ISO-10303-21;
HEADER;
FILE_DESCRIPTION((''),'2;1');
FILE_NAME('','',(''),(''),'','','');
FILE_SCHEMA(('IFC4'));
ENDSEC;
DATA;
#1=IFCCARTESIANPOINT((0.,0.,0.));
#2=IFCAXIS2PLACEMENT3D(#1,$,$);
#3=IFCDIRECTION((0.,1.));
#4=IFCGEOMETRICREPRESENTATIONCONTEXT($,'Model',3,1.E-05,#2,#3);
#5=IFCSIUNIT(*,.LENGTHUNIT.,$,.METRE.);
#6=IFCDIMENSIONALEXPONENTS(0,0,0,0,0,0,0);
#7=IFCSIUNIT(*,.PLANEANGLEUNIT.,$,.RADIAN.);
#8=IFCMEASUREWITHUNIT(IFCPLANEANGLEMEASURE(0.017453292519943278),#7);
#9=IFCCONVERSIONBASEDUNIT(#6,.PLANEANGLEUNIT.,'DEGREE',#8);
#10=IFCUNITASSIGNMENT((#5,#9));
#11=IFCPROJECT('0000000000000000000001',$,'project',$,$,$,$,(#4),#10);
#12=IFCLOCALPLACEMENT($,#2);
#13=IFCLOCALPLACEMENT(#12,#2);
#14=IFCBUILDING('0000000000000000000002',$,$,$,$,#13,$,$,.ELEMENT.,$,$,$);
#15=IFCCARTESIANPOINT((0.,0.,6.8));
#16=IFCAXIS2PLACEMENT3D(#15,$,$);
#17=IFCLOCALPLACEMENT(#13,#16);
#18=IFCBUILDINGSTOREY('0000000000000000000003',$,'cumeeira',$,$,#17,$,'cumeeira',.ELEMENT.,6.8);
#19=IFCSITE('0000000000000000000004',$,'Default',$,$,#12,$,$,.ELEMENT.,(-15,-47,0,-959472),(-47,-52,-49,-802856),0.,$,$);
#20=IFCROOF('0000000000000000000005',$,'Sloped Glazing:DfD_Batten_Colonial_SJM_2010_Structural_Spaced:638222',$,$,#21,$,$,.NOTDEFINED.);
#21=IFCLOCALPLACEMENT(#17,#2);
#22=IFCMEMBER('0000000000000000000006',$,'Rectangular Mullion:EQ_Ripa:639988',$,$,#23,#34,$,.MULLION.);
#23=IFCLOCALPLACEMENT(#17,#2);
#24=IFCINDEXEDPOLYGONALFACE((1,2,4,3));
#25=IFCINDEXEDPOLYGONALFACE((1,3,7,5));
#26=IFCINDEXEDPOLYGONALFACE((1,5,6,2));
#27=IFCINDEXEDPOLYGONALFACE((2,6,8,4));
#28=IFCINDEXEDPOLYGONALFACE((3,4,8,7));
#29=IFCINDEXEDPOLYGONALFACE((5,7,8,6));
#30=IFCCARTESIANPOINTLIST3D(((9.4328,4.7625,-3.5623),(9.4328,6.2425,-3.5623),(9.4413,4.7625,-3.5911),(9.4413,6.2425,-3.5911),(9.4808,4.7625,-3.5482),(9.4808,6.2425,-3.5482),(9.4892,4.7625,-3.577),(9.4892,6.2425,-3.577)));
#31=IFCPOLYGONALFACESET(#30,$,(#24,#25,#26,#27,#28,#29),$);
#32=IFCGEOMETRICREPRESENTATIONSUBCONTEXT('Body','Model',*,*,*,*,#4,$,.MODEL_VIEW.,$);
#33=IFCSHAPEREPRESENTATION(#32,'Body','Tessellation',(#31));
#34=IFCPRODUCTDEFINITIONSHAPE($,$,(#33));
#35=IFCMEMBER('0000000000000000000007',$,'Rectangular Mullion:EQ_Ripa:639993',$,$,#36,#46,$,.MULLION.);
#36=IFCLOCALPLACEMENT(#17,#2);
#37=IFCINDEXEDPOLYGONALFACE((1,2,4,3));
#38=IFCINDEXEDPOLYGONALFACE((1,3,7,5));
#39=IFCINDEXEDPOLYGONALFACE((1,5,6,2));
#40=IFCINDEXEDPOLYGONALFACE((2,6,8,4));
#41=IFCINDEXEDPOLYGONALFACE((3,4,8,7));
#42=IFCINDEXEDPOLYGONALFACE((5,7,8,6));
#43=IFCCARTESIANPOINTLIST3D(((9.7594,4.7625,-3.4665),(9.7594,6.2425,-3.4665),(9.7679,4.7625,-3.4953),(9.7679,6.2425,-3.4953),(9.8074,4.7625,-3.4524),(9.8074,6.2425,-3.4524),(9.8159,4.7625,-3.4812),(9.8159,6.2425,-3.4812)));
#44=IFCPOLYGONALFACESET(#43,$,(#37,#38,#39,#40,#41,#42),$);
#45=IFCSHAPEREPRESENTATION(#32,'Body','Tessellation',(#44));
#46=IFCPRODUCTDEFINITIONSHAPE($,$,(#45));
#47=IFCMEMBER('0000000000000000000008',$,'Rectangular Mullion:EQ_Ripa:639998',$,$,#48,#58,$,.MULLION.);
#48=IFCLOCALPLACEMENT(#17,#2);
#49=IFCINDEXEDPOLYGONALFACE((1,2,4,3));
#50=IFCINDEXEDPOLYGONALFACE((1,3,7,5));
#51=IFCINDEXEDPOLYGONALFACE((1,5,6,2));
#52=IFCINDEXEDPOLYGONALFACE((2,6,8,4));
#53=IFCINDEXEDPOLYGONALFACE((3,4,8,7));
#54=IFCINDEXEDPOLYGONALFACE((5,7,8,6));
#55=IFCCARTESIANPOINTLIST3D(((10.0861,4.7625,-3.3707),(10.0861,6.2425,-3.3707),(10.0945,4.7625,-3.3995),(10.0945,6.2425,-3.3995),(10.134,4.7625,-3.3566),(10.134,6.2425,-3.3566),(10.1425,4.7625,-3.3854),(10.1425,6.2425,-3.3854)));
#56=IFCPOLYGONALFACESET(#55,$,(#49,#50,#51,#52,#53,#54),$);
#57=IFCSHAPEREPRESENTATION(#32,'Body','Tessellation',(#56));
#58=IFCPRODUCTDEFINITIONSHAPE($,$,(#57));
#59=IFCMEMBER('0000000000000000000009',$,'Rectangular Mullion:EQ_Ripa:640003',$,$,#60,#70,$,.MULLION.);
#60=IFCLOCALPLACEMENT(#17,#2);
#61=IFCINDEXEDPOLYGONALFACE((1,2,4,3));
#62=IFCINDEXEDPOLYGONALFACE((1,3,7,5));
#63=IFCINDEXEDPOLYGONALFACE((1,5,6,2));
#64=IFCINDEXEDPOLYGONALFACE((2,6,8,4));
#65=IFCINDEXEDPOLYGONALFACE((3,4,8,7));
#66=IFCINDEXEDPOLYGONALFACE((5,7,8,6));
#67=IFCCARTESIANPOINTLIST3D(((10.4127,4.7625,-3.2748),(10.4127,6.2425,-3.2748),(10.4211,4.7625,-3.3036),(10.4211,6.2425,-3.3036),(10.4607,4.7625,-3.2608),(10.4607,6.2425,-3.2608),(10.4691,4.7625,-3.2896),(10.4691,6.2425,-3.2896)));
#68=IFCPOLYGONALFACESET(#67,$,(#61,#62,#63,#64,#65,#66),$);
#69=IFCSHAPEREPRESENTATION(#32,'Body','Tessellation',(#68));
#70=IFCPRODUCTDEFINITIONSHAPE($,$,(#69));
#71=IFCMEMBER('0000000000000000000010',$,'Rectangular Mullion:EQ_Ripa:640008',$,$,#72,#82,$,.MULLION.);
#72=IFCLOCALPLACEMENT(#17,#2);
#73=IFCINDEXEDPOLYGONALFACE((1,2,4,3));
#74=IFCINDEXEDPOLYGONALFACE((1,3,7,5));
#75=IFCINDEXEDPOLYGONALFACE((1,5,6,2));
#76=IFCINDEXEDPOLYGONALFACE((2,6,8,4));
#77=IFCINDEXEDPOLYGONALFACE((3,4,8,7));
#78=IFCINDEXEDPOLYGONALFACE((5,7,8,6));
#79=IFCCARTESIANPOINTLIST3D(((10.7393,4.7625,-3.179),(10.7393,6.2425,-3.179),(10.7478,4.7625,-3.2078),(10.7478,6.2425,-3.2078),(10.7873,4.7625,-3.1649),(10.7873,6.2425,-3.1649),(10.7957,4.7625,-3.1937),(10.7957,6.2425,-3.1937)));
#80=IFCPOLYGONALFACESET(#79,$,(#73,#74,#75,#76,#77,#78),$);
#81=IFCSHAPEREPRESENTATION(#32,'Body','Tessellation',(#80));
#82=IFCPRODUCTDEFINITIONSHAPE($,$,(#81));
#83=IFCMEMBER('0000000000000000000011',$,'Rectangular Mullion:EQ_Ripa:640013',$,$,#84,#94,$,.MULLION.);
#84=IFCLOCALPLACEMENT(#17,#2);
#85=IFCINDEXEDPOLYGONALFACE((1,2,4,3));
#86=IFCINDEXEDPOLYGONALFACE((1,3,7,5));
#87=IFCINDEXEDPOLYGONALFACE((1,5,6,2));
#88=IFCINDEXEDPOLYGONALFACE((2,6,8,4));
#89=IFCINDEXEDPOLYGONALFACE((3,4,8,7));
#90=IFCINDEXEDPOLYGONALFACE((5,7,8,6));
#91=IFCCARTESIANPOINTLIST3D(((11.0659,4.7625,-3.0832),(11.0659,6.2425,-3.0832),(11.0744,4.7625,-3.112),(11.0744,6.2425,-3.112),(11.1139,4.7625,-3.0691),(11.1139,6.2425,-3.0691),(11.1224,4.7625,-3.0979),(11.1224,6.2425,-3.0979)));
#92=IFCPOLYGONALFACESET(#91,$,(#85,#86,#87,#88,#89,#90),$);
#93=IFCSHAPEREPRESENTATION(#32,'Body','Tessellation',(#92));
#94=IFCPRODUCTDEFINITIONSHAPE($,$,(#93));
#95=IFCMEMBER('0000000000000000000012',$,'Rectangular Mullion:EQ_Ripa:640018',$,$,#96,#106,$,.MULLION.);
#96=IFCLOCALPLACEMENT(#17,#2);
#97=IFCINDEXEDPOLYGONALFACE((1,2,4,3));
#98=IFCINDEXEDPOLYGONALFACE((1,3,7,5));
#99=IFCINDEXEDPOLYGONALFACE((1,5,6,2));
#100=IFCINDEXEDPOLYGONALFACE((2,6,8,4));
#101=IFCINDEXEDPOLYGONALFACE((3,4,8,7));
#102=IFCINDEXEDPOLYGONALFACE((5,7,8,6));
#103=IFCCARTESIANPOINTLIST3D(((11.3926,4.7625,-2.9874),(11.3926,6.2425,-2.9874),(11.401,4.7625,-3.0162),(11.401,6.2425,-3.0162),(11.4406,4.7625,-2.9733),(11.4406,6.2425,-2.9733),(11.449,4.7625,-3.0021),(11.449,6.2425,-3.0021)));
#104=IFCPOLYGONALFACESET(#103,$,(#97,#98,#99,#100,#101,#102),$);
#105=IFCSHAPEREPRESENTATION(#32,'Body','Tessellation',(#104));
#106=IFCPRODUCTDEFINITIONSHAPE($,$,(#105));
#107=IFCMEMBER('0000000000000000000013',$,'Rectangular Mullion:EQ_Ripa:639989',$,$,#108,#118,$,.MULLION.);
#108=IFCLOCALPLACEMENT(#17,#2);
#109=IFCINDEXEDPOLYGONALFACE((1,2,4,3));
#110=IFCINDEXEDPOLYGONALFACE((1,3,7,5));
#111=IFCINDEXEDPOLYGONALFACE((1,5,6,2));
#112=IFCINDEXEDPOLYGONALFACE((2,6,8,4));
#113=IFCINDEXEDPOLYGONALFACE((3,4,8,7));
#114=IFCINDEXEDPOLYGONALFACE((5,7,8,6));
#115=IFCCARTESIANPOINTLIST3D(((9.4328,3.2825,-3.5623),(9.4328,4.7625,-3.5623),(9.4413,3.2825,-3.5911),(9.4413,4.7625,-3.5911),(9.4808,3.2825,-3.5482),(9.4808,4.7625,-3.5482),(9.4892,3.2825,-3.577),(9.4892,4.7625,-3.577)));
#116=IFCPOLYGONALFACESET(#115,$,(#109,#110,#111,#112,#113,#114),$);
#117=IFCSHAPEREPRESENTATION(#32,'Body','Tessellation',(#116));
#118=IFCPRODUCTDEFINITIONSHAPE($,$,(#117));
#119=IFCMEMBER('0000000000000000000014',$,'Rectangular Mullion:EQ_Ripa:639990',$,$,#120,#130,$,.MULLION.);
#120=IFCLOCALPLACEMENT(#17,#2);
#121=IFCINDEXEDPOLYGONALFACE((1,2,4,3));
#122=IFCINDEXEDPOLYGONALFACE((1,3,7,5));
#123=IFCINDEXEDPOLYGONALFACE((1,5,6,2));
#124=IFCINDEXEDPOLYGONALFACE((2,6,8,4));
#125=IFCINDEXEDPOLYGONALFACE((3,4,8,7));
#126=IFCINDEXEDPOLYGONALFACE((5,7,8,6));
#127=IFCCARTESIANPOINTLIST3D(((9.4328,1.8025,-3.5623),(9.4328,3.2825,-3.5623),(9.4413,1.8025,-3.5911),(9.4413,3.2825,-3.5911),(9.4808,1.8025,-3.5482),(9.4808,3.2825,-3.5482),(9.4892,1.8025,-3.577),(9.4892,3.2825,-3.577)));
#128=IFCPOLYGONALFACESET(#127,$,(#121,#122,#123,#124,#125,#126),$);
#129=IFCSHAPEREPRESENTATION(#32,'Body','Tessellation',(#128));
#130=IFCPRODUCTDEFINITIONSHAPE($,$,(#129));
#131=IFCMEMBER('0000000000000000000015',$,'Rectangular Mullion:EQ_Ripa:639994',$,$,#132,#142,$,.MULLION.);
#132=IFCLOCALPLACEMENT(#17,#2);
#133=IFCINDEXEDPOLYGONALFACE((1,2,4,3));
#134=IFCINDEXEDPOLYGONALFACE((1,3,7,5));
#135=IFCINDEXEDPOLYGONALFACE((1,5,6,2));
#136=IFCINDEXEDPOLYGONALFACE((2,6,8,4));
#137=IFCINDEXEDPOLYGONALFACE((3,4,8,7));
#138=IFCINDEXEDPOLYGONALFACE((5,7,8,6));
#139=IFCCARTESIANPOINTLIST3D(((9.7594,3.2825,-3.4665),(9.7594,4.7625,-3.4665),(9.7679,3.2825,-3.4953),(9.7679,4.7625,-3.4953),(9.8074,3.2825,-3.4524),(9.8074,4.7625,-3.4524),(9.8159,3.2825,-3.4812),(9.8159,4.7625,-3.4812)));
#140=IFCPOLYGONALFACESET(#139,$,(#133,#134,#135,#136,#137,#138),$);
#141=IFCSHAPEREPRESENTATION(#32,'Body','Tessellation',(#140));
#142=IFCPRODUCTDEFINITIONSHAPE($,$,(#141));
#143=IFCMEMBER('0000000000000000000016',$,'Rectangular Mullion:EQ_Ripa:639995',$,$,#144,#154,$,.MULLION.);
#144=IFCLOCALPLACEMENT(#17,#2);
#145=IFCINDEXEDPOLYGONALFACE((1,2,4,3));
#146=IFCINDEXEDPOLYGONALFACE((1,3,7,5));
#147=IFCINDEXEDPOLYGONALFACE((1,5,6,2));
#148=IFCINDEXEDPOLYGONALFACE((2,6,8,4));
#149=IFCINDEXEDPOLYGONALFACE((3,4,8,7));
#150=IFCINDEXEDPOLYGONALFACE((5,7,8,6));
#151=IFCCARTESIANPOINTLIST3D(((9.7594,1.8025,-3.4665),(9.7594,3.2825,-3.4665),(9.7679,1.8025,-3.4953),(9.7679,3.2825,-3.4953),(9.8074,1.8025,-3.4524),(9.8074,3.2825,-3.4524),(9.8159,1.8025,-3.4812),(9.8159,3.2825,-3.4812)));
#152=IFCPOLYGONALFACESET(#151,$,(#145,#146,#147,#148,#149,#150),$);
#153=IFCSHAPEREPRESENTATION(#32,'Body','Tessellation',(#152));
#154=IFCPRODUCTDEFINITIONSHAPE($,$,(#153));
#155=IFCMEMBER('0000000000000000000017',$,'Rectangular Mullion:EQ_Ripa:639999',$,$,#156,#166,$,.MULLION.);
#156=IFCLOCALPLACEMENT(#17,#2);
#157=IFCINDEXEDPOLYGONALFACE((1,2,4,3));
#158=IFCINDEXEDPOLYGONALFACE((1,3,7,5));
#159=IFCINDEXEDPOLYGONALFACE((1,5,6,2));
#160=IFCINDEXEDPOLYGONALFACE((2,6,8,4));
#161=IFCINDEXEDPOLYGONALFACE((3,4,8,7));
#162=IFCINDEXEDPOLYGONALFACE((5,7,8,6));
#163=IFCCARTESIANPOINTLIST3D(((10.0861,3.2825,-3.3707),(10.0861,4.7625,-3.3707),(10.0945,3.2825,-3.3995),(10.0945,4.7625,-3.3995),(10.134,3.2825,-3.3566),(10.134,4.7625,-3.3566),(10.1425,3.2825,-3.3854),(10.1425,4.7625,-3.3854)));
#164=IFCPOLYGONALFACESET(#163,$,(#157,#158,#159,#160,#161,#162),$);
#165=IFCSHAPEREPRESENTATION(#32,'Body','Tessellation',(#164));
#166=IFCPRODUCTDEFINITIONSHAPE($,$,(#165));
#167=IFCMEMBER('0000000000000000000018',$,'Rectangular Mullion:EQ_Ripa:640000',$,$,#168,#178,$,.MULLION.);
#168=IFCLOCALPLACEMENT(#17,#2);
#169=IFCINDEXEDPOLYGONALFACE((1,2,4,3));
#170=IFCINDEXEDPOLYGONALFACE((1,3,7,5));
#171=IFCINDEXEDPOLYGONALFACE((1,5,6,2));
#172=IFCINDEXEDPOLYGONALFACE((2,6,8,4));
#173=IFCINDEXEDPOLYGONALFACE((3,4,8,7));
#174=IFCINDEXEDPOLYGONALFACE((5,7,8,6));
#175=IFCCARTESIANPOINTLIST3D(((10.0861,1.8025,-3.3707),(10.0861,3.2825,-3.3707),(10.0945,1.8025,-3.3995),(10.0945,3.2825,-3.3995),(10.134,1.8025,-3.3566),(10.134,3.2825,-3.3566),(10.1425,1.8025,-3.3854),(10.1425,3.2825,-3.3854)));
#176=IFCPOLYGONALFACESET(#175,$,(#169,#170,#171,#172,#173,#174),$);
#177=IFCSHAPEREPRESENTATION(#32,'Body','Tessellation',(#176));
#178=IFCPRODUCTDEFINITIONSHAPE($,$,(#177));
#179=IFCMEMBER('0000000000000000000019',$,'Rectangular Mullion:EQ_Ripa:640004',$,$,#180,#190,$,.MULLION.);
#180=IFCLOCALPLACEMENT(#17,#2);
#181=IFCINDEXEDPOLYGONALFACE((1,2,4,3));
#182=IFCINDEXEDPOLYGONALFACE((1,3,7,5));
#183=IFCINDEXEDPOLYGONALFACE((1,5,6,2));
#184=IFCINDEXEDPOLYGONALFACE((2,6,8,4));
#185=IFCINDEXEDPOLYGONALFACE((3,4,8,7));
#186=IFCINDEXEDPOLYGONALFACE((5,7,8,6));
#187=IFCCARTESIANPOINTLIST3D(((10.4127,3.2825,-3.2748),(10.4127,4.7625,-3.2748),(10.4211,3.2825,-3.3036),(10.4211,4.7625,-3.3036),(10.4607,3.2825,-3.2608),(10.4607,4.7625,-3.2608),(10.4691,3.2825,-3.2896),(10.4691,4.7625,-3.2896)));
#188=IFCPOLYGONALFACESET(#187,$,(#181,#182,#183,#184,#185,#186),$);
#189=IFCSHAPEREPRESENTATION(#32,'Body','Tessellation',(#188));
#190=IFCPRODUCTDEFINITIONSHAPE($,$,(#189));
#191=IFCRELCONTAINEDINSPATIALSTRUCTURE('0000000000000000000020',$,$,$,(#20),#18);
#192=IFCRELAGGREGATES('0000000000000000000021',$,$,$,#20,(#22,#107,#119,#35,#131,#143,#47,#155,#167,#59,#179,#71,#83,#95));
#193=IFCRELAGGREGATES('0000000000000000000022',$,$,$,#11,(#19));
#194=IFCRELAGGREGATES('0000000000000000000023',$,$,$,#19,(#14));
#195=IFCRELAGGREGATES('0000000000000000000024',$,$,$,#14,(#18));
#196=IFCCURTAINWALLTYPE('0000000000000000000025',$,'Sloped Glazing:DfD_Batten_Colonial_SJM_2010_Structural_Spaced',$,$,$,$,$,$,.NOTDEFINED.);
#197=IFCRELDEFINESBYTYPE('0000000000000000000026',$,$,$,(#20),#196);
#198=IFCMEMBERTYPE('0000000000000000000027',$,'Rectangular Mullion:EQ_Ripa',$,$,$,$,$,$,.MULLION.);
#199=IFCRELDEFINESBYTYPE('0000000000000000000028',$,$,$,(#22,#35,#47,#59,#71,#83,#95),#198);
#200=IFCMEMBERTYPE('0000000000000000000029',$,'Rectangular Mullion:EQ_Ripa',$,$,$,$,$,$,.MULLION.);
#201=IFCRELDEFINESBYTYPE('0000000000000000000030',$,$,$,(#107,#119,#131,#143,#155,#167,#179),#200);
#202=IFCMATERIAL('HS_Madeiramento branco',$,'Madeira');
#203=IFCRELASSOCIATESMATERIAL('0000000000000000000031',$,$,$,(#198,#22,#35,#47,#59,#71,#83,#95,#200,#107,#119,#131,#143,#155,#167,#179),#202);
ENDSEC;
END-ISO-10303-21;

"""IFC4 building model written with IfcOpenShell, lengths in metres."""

from ifc_helpers import new_model, entity, si_unit, converted_unit, direction, frame, origin, place, context, subcontext, project, spatial, indexed_curve, outline, extrude, source, transform, mapped, material, type_object, type_shapes, element, aggregate, save


model = new_model("IFC4")

# Units and contexts
model_context = context("Model", 3, precision=1e-05, world=origin(), true_north=direction((0.0, 1.0)))
body_context = subcontext(model_context, "Body", "Model", "MODEL_VIEW")
ifc_project = project(units=[si_unit("LENGTHUNIT", "METRE"), converted_unit("PLANEANGLEUNIT", "DEGREE", entity("IfcPlaneAngleMeasure", 0.017453292519943278), si_unit("PLANEANGLEUNIT", "RADIAN"), dimensions=[0, 0, 0, 0, 0, 0, 0])], contexts=[model_context])

# Site, building, storey
site_placement = place(None, origin())
site = spatial("IfcSite", under=ifc_project, at=site_placement, Name="Default", CompositionType="ELEMENT", RefLatitude=(-15, -47, 0, -959472), RefLongitude=(-47, -52, -49, -802856), RefElevation=0.0)
building_placement = place(site_placement, origin())
building = spatial("IfcBuilding", under=site, at=building_placement, CompositionType="ELEMENT")
storey_placement = place(building_placement, frame((0.0, 0.0, 6.8)))
storey = spatial("IfcBuildingStorey", under=building, at=storey_placement, Name="cumeeira", LongName="cumeeira", CompositionType="ELEMENT", Elevation=6.8)

# Roof, members
curtain_wall_type = type_object("IfcCurtainWallType", Name="Sloped Glazing:DfD_Batten_Colonial_SJM_2010_Structural_Spaced", PredefinedType="NOTDEFINED")
roof_placement = place(storey_placement, frame((0.0, 0.0, -6.8)))
roof = element("IfcRoof", 1, at=roof_placement, inside=storey, type_object=curtain_wall_type, Name="Sloped Glazing:DfD_Batten_Colonial_SJM_2010_Structural_Spaced:638222", PredefinedType="NOTDEFINED")
ifc_material = material(Name="HS_Madeiramento branco", Category="Madeira")
member_type_1 = type_object("IfcMemberType", Name="Rectangular Mullion:EQ_Ripa", PredefinedType="MULLION", material=ifc_material)
shared_shape_1 = source(origin(), body_context, "Body", "SweptSolid", [
    extrude(outline(indexed_curve([(-0.025, -0.015), (0.025, -0.015), (0.025, 0.015), (-0.025, 0.015), (-0.025, -0.015)], self_intersect=False)), frame((0.0, 0.0, -1.48), z_axis=(0.0, 0.0, 1.0), x_axis=(-1.0, 0.0, 0.0)), (0.0, 0.0, 1.0), 1.48),
])
type_shapes(member_type_1, [shared_shape_1])
member_1_placement = place(roof_placement, frame((9.461, 6.2425, 3.2303), z_axis=(0.0, 1.0, 0.0), x_axis=(0.95956, 0.0, 0.281504)))
member_1 = element("IfcMember", 2, at=member_1_placement, type_object=member_type_1, material=ifc_material, Name="Rectangular Mullion:EQ_Ripa:639988", PredefinedType="MULLION", context=body_context, shape_type="MappedRepresentation", body=[
    mapped(shared_shape_1, transform((0.0, 0.0, 0.0), scale=1.0)),
])
member_2_placement = place(roof_placement, frame((9.7877, 6.2425, 3.3262), z_axis=(0.0, 1.0, 0.0), x_axis=(0.95956, 0.0, 0.281504)))
member_2 = element("IfcMember", 3, at=member_2_placement, type_object=member_type_1, material=ifc_material, Name="Rectangular Mullion:EQ_Ripa:639993", PredefinedType="MULLION", context=body_context, shape_type="MappedRepresentation", body=[
    mapped(shared_shape_1, transform((0.0, 0.0, 0.0), scale=1.0)),
])
member_3_placement = place(roof_placement, frame((10.1143, 6.2425, 3.422), z_axis=(0.0, 1.0, 0.0), x_axis=(0.95956, 0.0, 0.281504)))
member_3 = element("IfcMember", 4, at=member_3_placement, type_object=member_type_1, material=ifc_material, Name="Rectangular Mullion:EQ_Ripa:639998", PredefinedType="MULLION", context=body_context, shape_type="MappedRepresentation", body=[
    mapped(shared_shape_1, transform((0.0, 0.0, 0.0), scale=1.0)),
])
member_4_placement = place(roof_placement, frame((10.4409, 6.2425, 3.5178), z_axis=(0.0, 1.0, 0.0), x_axis=(0.95956, 0.0, 0.281504)))
member_4 = element("IfcMember", 5, at=member_4_placement, type_object=member_type_1, material=ifc_material, Name="Rectangular Mullion:EQ_Ripa:640003", PredefinedType="MULLION", context=body_context, shape_type="MappedRepresentation", body=[
    mapped(shared_shape_1, transform((0.0, 0.0, 0.0), scale=1.0)),
])
member_5_placement = place(roof_placement, frame((10.7675, 6.2425, 3.6136), z_axis=(0.0, 1.0, 0.0), x_axis=(0.95956, 0.0, 0.281504)))
member_5 = element("IfcMember", 6, at=member_5_placement, type_object=member_type_1, material=ifc_material, Name="Rectangular Mullion:EQ_Ripa:640008", PredefinedType="MULLION", context=body_context, shape_type="MappedRepresentation", body=[
    mapped(shared_shape_1, transform((0.0, 0.0, 0.0), scale=1.0)),
])
member_6_placement = place(roof_placement, frame((11.0942, 6.2425, 3.7094), z_axis=(0.0, 1.0, 0.0), x_axis=(0.95956, 0.0, 0.281504)))
member_6 = element("IfcMember", 7, at=member_6_placement, type_object=member_type_1, material=ifc_material, Name="Rectangular Mullion:EQ_Ripa:640013", PredefinedType="MULLION", context=body_context, shape_type="MappedRepresentation", body=[
    mapped(shared_shape_1, transform((0.0, 0.0, 0.0), scale=1.0)),
])
member_7_placement = place(roof_placement, frame((11.4208, 6.2425, 3.8053), z_axis=(0.0, 1.0, 0.0), x_axis=(0.95956, 0.0, 0.281504)))
member_7 = element("IfcMember", 8, at=member_7_placement, type_object=member_type_1, material=ifc_material, Name="Rectangular Mullion:EQ_Ripa:640018", PredefinedType="MULLION", context=body_context, shape_type="MappedRepresentation", body=[
    mapped(shared_shape_1, transform((0.0, 0.0, 0.0), scale=1.0)),
])
member_type_2 = type_object("IfcMemberType", Name="Rectangular Mullion:EQ_Ripa", PredefinedType="MULLION", material=ifc_material)
shared_shape_2 = source(origin(), body_context, "Body", "SweptSolid", [
    extrude(outline(indexed_curve([(-0.025, -0.015), (0.025, -0.015), (0.025, 0.015), (-0.025, 0.015), (-0.025, -0.015)], self_intersect=False)), frame((0.0, 0.0, -1.48), z_axis=(0.0, 0.0, 1.0), x_axis=(-1.0, 0.0, 0.0)), (0.0, 0.0, 1.0), 1.48),
])
type_shapes(member_type_2, [shared_shape_2])
member_8_placement = place(roof_placement, frame((9.461, 4.7625, 3.2303), z_axis=(0.0, 1.0, 0.0), x_axis=(0.95956, 0.0, 0.281504)))
member_8 = element("IfcMember", 9, at=member_8_placement, type_object=member_type_2, material=ifc_material, Name="Rectangular Mullion:EQ_Ripa:639989", PredefinedType="MULLION", context=body_context, shape_type="MappedRepresentation", body=[
    mapped(shared_shape_2, transform((0.0, 0.0, 0.0), scale=1.0)),
])
member_9_placement = place(roof_placement, frame((9.461, 3.2825, 3.2303), z_axis=(0.0, 1.0, 0.0), x_axis=(0.95956, 0.0, 0.281504)))
member_9 = element("IfcMember", 10, at=member_9_placement, type_object=member_type_2, material=ifc_material, Name="Rectangular Mullion:EQ_Ripa:639990", PredefinedType="MULLION", context=body_context, shape_type="MappedRepresentation", body=[
    mapped(shared_shape_2, transform((0.0, 0.0, 0.0), scale=1.0)),
])
member_10_placement = place(roof_placement, frame((9.7877, 4.7625, 3.3262), z_axis=(0.0, 1.0, 0.0), x_axis=(0.95956, 0.0, 0.281504)))
member_10 = element("IfcMember", 11, at=member_10_placement, type_object=member_type_2, material=ifc_material, Name="Rectangular Mullion:EQ_Ripa:639994", PredefinedType="MULLION", context=body_context, shape_type="MappedRepresentation", body=[
    mapped(shared_shape_2, transform((0.0, 0.0, 0.0), scale=1.0)),
])
member_11_placement = place(roof_placement, frame((9.7877, 3.2825, 3.3262), z_axis=(0.0, 1.0, 0.0), x_axis=(0.95956, 0.0, 0.281504)))
member_11 = element("IfcMember", 12, at=member_11_placement, type_object=member_type_2, material=ifc_material, Name="Rectangular Mullion:EQ_Ripa:639995", PredefinedType="MULLION", context=body_context, shape_type="MappedRepresentation", body=[
    mapped(shared_shape_2, transform((0.0, 0.0, 0.0), scale=1.0)),
])
member_12_placement = place(roof_placement, frame((10.1143, 4.7625, 3.422), z_axis=(0.0, 1.0, 0.0), x_axis=(0.95956, 0.0, 0.281504)))
member_12 = element("IfcMember", 13, at=member_12_placement, type_object=member_type_2, material=ifc_material, Name="Rectangular Mullion:EQ_Ripa:639999", PredefinedType="MULLION", context=body_context, shape_type="MappedRepresentation", body=[
    mapped(shared_shape_2, transform((0.0, 0.0, 0.0), scale=1.0)),
])
member_13_placement = place(roof_placement, frame((10.1143, 3.2825, 3.422), z_axis=(0.0, 1.0, 0.0), x_axis=(0.95956, 0.0, 0.281504)))
member_13 = element("IfcMember", 14, at=member_13_placement, type_object=member_type_2, material=ifc_material, Name="Rectangular Mullion:EQ_Ripa:640000", PredefinedType="MULLION", context=body_context, shape_type="MappedRepresentation", body=[
    mapped(shared_shape_2, transform((0.0, 0.0, 0.0), scale=1.0)),
])
member_14_placement = place(roof_placement, frame((10.4409, 4.7625, 3.5178), z_axis=(0.0, 1.0, 0.0), x_axis=(0.95956, 0.0, 0.281504)))
member_14 = element("IfcMember", 15, at=member_14_placement, type_object=member_type_2, material=ifc_material, Name="Rectangular Mullion:EQ_Ripa:640004", PredefinedType="MULLION", context=body_context, shape_type="MappedRepresentation", body=[
    mapped(shared_shape_2, transform((0.0, 0.0, 0.0), scale=1.0)),
])
aggregate(roof, [member_1, member_8, member_9, member_2, member_10, member_11, member_3, member_12, member_13, member_4, member_14, member_5, member_6, member_7])

save(model, "model.ifc")
